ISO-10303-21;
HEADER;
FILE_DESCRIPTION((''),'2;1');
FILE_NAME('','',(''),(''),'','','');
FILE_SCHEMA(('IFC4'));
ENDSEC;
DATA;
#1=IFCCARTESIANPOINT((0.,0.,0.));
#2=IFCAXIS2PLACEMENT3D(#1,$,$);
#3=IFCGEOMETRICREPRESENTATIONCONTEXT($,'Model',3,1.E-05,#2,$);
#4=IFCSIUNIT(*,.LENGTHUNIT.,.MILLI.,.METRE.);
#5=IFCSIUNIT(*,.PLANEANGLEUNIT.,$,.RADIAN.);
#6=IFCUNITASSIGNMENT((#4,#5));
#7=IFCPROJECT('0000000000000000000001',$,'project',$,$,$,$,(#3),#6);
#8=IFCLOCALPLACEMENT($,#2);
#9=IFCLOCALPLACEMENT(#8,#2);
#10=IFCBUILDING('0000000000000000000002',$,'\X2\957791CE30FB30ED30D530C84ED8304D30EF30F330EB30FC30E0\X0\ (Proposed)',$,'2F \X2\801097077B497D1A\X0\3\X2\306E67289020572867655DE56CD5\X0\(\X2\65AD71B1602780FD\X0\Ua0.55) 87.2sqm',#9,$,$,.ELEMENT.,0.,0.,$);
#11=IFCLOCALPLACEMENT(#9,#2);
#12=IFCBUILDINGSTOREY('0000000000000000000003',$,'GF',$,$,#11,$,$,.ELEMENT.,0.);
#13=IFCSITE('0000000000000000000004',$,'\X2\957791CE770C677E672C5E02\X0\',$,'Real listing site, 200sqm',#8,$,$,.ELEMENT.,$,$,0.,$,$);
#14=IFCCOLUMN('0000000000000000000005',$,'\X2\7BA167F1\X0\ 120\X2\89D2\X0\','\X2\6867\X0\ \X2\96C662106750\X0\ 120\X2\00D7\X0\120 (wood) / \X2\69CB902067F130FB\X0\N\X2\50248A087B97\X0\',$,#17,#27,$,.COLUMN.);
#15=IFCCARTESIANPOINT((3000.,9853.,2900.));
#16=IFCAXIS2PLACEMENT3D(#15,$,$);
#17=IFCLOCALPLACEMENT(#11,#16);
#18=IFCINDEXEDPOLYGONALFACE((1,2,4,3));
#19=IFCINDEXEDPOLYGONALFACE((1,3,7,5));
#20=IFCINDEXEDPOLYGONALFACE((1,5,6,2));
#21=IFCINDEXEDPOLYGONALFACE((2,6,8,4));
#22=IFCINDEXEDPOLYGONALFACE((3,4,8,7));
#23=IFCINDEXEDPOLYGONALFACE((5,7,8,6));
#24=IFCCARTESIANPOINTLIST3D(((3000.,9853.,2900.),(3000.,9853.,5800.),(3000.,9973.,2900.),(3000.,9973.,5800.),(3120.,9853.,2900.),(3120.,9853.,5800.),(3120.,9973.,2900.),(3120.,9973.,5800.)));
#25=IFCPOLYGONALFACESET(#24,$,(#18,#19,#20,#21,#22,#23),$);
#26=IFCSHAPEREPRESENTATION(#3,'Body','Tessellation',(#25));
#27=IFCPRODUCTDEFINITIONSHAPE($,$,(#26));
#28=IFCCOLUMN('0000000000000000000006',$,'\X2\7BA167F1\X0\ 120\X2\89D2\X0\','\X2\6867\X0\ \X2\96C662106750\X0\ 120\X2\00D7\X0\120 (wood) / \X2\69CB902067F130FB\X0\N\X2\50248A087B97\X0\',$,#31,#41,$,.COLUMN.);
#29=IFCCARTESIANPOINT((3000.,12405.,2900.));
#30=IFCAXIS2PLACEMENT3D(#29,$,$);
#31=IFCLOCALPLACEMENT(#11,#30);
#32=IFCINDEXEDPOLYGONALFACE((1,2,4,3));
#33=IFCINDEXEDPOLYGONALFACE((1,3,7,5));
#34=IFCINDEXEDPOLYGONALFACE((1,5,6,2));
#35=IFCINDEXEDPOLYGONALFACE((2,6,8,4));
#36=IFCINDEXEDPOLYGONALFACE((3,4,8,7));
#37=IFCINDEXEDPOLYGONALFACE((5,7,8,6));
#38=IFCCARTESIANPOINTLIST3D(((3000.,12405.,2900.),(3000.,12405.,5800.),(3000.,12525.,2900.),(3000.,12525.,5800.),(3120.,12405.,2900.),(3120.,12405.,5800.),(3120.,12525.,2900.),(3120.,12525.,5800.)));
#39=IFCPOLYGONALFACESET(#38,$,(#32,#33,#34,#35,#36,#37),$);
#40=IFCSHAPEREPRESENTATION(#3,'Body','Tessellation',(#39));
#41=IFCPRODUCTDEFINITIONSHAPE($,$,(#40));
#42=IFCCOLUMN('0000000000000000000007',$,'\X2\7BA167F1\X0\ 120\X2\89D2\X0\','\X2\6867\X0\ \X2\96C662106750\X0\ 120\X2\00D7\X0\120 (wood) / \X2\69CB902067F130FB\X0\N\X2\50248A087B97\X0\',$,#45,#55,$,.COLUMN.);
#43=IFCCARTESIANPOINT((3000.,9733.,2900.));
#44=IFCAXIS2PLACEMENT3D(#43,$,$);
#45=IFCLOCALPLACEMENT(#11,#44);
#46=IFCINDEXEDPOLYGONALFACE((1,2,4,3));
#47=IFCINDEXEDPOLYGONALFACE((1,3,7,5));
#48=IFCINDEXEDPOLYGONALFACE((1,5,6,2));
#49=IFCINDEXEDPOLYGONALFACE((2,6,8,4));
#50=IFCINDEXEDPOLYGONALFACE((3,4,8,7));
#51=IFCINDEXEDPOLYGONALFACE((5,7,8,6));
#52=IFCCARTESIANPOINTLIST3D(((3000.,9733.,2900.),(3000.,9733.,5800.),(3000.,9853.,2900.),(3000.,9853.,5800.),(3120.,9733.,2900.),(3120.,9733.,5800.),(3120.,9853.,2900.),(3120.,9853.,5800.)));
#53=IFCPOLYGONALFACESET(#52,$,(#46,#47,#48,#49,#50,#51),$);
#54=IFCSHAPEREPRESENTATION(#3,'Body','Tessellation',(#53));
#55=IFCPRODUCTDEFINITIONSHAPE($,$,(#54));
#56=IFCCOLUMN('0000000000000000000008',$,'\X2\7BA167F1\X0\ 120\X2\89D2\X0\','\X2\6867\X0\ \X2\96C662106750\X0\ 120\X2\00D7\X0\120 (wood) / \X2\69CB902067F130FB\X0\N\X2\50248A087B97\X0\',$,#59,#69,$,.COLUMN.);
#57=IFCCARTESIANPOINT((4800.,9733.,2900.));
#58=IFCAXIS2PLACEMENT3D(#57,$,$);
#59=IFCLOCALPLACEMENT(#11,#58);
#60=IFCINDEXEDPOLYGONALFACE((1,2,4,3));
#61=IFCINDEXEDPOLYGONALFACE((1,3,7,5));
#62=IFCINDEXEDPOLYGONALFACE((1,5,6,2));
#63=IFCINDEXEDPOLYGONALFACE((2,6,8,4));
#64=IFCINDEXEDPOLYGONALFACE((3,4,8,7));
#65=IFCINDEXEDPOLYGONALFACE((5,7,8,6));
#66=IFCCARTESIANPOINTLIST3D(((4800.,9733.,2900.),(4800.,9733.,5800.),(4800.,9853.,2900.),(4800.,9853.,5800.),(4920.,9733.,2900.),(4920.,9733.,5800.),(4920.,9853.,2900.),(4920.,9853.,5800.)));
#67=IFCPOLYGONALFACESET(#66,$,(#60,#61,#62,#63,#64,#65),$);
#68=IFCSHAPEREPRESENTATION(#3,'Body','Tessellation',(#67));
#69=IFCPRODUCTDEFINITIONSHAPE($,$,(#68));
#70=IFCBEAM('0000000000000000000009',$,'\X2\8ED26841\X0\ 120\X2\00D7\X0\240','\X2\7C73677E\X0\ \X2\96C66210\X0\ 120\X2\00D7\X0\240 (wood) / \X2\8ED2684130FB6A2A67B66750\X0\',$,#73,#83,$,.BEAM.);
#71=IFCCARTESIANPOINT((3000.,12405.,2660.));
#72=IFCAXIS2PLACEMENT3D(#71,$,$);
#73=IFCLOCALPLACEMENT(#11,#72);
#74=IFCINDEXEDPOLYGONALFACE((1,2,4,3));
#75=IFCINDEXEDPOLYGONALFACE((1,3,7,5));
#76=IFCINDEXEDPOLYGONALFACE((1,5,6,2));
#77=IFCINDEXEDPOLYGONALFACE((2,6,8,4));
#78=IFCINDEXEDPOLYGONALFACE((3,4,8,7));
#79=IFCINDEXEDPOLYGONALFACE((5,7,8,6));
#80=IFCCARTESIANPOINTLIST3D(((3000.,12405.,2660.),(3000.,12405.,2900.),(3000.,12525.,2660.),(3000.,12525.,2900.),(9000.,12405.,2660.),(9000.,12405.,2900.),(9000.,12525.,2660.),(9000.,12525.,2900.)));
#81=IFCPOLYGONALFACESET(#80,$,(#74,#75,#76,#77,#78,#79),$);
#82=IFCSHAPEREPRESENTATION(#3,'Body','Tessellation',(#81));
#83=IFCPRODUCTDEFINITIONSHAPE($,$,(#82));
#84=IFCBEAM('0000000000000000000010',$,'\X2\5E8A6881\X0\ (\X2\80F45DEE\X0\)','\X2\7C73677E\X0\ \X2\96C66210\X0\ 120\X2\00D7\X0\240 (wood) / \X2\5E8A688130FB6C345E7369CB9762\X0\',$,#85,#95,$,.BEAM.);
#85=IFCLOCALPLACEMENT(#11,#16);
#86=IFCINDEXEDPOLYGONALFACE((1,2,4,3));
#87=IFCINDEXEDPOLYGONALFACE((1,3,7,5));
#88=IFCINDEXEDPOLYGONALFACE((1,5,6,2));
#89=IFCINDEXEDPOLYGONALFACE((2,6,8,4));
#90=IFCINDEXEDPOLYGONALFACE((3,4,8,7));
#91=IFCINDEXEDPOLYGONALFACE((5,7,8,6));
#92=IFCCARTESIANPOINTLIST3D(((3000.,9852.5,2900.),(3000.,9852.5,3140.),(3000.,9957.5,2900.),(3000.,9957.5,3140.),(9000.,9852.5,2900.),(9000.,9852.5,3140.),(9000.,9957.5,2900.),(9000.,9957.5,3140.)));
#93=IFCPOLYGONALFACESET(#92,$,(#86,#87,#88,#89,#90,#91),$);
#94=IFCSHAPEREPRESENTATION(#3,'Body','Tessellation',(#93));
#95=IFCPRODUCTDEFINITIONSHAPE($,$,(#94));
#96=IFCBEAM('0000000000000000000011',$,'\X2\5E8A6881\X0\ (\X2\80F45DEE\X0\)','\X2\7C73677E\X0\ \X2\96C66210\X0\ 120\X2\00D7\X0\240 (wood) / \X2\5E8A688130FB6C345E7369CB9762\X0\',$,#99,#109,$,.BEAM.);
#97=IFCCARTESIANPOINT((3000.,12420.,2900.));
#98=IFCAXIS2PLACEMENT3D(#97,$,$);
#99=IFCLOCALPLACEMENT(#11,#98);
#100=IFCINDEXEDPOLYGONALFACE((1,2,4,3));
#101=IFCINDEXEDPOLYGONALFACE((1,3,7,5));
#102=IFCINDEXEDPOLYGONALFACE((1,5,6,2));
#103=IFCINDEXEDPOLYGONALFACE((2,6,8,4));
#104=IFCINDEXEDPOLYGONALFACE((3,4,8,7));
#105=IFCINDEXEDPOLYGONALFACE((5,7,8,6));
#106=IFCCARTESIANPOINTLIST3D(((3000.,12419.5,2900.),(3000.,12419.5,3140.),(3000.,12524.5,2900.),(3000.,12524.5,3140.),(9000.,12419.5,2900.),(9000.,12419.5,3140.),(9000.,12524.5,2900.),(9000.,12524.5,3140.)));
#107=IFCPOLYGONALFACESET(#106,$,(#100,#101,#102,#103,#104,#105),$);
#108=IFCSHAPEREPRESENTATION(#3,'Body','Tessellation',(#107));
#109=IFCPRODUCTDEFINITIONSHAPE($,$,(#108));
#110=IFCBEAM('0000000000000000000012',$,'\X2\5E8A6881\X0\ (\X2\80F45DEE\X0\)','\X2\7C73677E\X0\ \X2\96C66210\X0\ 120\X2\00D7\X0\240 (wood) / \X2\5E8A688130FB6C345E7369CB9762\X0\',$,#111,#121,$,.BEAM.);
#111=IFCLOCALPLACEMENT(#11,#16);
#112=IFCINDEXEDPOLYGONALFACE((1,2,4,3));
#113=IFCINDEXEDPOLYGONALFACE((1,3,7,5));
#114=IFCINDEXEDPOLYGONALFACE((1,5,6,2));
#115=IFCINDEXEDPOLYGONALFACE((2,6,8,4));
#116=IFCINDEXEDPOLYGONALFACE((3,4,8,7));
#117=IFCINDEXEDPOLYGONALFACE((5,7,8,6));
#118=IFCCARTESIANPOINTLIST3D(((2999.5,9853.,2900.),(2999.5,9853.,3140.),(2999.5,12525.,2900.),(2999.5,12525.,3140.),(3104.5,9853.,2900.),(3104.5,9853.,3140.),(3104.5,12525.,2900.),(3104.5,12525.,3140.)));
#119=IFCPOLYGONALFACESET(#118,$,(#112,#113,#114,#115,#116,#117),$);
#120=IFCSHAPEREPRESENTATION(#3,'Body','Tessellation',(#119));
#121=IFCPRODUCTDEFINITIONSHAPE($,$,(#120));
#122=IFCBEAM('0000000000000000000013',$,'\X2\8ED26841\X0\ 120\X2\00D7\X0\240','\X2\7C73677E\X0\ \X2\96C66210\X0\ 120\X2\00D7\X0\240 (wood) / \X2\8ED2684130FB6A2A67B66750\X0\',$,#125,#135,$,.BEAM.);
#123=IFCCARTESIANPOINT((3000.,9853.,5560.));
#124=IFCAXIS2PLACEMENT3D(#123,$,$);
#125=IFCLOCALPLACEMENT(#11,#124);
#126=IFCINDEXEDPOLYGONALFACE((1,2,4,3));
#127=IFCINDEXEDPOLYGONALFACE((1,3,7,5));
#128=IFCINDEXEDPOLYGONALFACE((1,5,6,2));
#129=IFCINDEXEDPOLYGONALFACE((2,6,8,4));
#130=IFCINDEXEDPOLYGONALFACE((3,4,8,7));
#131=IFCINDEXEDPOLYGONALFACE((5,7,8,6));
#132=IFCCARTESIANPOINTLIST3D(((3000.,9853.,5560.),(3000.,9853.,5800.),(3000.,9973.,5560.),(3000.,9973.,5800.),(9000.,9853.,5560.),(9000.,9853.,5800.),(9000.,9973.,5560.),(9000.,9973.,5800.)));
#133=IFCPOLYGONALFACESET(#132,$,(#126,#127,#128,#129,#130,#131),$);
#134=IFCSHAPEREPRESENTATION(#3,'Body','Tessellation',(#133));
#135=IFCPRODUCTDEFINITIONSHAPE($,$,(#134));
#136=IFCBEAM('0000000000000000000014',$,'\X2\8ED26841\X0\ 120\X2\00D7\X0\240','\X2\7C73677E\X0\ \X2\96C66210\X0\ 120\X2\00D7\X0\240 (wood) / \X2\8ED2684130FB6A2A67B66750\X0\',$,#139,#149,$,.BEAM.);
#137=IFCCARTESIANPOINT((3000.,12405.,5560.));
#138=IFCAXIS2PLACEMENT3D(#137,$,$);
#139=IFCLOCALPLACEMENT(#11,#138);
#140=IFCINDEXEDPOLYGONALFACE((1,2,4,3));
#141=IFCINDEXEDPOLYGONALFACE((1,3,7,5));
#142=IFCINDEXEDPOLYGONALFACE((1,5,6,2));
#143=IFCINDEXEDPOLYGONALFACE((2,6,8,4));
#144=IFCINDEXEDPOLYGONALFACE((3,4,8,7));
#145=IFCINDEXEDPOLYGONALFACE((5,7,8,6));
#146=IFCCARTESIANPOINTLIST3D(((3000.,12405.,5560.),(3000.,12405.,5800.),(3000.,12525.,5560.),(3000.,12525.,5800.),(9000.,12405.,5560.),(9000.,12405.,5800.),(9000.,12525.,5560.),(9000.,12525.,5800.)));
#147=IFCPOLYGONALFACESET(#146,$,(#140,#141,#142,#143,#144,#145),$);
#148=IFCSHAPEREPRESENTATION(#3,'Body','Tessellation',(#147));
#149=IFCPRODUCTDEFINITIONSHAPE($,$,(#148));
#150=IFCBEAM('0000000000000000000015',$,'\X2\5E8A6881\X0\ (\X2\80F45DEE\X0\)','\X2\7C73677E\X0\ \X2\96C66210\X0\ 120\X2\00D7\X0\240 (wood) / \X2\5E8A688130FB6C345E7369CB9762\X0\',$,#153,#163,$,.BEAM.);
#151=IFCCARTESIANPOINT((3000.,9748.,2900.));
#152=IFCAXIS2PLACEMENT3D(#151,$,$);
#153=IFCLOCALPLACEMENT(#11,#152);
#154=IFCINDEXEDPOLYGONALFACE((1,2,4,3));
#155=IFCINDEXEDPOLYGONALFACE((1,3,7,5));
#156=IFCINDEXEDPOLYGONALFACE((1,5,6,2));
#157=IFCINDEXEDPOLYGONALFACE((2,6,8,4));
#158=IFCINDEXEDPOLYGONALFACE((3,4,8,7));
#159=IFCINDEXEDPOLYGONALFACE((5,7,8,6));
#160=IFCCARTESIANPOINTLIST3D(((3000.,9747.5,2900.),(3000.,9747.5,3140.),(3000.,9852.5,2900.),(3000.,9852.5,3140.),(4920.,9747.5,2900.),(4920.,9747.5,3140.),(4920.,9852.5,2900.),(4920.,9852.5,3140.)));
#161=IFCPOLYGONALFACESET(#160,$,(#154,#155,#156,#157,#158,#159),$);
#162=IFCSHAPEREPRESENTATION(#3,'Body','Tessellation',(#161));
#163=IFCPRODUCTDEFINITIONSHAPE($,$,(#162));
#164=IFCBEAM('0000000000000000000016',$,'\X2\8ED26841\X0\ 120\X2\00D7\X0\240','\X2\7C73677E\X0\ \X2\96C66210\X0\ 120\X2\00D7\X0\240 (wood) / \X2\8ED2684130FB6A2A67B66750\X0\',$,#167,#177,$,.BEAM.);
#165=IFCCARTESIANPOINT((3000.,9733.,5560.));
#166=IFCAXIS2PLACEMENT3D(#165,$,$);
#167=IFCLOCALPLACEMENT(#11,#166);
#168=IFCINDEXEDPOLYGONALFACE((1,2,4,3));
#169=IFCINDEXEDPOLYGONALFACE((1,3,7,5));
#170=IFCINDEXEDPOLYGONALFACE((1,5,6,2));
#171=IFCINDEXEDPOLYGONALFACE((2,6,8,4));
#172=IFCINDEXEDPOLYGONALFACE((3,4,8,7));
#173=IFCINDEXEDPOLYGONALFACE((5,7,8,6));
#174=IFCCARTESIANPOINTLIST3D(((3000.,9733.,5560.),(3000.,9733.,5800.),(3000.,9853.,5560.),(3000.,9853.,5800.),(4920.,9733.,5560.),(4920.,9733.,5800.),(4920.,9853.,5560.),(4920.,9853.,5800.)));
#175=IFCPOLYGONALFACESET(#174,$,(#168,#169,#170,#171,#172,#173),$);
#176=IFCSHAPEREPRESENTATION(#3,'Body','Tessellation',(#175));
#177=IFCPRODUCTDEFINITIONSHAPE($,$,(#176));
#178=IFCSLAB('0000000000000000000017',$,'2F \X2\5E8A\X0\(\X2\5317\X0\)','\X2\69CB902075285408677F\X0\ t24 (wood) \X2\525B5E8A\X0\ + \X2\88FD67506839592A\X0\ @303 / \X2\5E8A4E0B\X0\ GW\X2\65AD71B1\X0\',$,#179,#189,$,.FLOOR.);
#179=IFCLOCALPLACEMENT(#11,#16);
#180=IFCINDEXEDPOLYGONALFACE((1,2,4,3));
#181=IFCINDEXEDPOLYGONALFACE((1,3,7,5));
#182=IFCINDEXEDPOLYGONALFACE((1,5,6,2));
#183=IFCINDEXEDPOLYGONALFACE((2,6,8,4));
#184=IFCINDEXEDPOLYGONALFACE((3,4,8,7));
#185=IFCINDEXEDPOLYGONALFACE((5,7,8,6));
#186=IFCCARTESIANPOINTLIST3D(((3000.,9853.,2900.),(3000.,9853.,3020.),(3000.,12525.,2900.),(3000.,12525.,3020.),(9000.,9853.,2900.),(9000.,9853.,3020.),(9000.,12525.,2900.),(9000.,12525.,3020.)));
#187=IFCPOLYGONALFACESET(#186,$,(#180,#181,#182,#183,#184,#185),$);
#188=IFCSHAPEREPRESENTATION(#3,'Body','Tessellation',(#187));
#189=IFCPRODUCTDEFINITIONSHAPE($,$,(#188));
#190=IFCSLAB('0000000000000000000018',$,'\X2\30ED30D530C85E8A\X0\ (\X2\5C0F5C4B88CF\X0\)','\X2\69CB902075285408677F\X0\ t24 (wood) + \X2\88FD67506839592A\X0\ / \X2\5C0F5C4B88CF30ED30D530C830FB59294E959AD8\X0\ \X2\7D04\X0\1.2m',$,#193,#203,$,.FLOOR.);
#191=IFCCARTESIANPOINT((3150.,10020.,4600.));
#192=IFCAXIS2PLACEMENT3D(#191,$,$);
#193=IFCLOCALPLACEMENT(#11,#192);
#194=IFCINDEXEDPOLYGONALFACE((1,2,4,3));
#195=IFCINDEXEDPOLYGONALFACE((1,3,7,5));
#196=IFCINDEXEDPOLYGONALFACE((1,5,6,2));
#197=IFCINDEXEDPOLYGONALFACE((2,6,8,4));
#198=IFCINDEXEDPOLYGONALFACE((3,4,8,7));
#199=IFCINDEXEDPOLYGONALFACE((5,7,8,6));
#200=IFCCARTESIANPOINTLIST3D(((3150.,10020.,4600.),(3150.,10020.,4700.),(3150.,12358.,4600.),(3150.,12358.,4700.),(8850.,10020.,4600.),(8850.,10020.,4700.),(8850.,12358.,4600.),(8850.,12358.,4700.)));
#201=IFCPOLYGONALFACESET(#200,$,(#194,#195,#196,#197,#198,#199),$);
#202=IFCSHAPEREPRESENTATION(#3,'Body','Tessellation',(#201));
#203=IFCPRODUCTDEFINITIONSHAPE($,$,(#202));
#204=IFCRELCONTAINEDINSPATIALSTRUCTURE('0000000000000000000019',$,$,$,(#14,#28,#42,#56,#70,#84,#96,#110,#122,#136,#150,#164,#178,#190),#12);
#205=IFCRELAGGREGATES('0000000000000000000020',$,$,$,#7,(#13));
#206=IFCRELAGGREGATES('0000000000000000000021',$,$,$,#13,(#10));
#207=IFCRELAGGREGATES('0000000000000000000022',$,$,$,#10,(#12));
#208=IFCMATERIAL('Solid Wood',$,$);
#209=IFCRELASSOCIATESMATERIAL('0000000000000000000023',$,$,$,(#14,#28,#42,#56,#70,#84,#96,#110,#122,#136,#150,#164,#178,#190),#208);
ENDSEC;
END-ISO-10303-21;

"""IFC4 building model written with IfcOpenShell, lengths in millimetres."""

from ifc_helpers import new_model, si_unit, frame, frame_2d, origin, place, context, project, spatial, rectangle, extrude, material, element, save


model = new_model("IFC4")

# Units and contexts
model_context = context("Model", 3, precision=1e-05, world=origin())
ifc_project = project(units=[si_unit("LENGTHUNIT", "METRE", prefix="MILLI"), si_unit("PLANEANGLEUNIT", "RADIAN")], contexts=[model_context])

# Site, building, storey
site_placement = place(None, origin())
site = spatial("IfcSite", under=ifc_project, at=site_placement, Name="長野県松本市", ObjectType="Real listing site, 200sqm", CompositionType="ELEMENT", RefElevation=0.0)
building_placement = place(site_placement, origin())
building = spatial("IfcBuilding", under=site, at=building_placement, Name="長野・ロフト付きワンルーム (Proposed)", ObjectType="2F 耐震等級3の木造在来工法(断熱性能Ua0.55) 87.2sqm", CompositionType="ELEMENT", ElevationOfRefHeight=0.0, ElevationOfTerrain=0.0)
storey_placement = place(building_placement, origin())
storey = spatial("IfcBuildingStorey", under=building, at=storey_placement, Name="GF", CompositionType="ELEMENT", Elevation=0.0)

# Columns
ifc_material_1 = material(Name="Solid Wood")
column_1_placement = place(storey_placement, frame((3000.0, 9853.0, 2900.0)))
element("IfcColumn", 1, at=column_1_placement, inside=storey, material=ifc_material_1, Name="管柱 120角", Description="桧 集成材 120×120 (wood) / 構造柱・N値計算", PredefinedType="COLUMN", context=model_context, shape_type="SweptSolid", body=[
    extrude(rectangle(XDim=120.0, YDim=120.0, at=frame_2d((60.0, 60.0))), frame((3000.0, 9853.0, 2900.0)), (0.0, 0.0, 1.0), 2900.0),
])
column_2_placement = place(storey_placement, frame((3000.0, 12405.0, 2900.0)))
element("IfcColumn", 2, at=column_2_placement, inside=storey, material=ifc_material_1, Name="管柱 120角", Description="桧 集成材 120×120 (wood) / 構造柱・N値計算", PredefinedType="COLUMN", context=model_context, shape_type="SweptSolid", body=[
    extrude(rectangle(XDim=120.0, YDim=120.0, at=frame_2d((60.0, 60.0))), frame((3000.0, 12405.0, 2900.0)), (0.0, 0.0, 1.0), 2900.0),
])
column_3_placement = place(storey_placement, frame((3000.0, 9733.0, 2900.0)))
element("IfcColumn", 3, at=column_3_placement, inside=storey, material=ifc_material_1, Name="管柱 120角", Description="桧 集成材 120×120 (wood) / 構造柱・N値計算", PredefinedType="COLUMN", context=model_context, shape_type="SweptSolid", body=[
    extrude(rectangle(XDim=120.0, YDim=120.0, at=frame_2d((60.0, 60.0))), frame((3000.0, 9733.0, 2900.0)), (0.0, 0.0, 1.0), 2900.0),
])
column_4_placement = place(storey_placement, frame((4800.0, 9733.0, 2900.0)))
element("IfcColumn", 4, at=column_4_placement, inside=storey, material=ifc_material_1, Name="管柱 120角", Description="桧 集成材 120×120 (wood) / 構造柱・N値計算", PredefinedType="COLUMN", context=model_context, shape_type="SweptSolid", body=[
    extrude(rectangle(XDim=120.0, YDim=120.0, at=frame_2d((60.0, 60.0))), frame((4800.0, 9733.0, 2900.0)), (0.0, 0.0, 1.0), 2900.0),
])

# Beams
beam_1_placement = place(storey_placement, frame((3000.0, 12405.0, 2660.0)))
element("IfcBeam", 5, at=beam_1_placement, inside=storey, material=ifc_material_1, Name="軒桁 120×240", Description="米松 集成 120×240 (wood) / 軒桁・横架材", PredefinedType="BEAM", context=model_context, shape_type="SweptSolid", body=[
    extrude(rectangle(XDim=6000.0, YDim=120.0, at=frame_2d((3000.0, 60.0))), frame((3000.0, 12405.0, 2660.0)), (0.0, 0.0, 1.0), 240.0),
])
beam_2_placement = place(storey_placement, frame((3000.0, 9853.0, 2900.0)))
element("IfcBeam", 6, at=beam_2_placement, inside=storey, material=ifc_material_1, Name="床梁 (胴差)", Description="米松 集成 120×240 (wood) / 床梁・水平構面", PredefinedType="BEAM", context=model_context, shape_type="SweptSolid", body=[
    extrude(rectangle(XDim=6000.0, YDim=105.0, at=frame_2d((3000.0, 52.0))), frame((3000.0, 9853.0, 2900.0)), (0.0, 0.0, 1.0), 240.0),
])
beam_3_placement = place(storey_placement, frame((3000.0, 12420.0, 2900.0)))
element("IfcBeam", 7, at=beam_3_placement, inside=storey, material=ifc_material_1, Name="床梁 (胴差)", Description="米松 集成 120×240 (wood) / 床梁・水平構面", PredefinedType="BEAM", context=model_context, shape_type="SweptSolid", body=[
    extrude(rectangle(XDim=6000.0, YDim=105.0, at=frame_2d((3000.0, 52.0))), frame((3000.0, 12420.0, 2900.0)), (0.0, 0.0, 1.0), 240.0),
])
beam_4_placement = place(storey_placement, frame((3000.0, 9853.0, 2900.0)))
element("IfcBeam", 8, at=beam_4_placement, inside=storey, material=ifc_material_1, Name="床梁 (胴差)", Description="米松 集成 120×240 (wood) / 床梁・水平構面", PredefinedType="BEAM", context=model_context, shape_type="SweptSolid", body=[
    extrude(rectangle(XDim=105.0, YDim=2672.0, at=frame_2d((52.0, 1336.0))), frame((3000.0, 9853.0, 2900.0)), (0.0, 0.0, 1.0), 240.0),
])
beam_5_placement = place(storey_placement, frame((3000.0, 9853.0, 5560.0)))
element("IfcBeam", 9, at=beam_5_placement, inside=storey, material=ifc_material_1, Name="軒桁 120×240", Description="米松 集成 120×240 (wood) / 軒桁・横架材", PredefinedType="BEAM", context=model_context, shape_type="SweptSolid", body=[
    extrude(rectangle(XDim=6000.0, YDim=120.0, at=frame_2d((3000.0, 60.0))), frame((3000.0, 9853.0, 5560.0)), (0.0, 0.0, 1.0), 240.0),
])
beam_6_placement = place(storey_placement, frame((3000.0, 12405.0, 5560.0)))
element("IfcBeam", 10, at=beam_6_placement, inside=storey, material=ifc_material_1, Name="軒桁 120×240", Description="米松 集成 120×240 (wood) / 軒桁・横架材", PredefinedType="BEAM", context=model_context, shape_type="SweptSolid", body=[
    extrude(rectangle(XDim=6000.0, YDim=120.0, at=frame_2d((3000.0, 60.0))), frame((3000.0, 12405.0, 5560.0)), (0.0, 0.0, 1.0), 240.0),
])
beam_7_placement = place(storey_placement, frame((3000.0, 9748.0, 2900.0)))
element("IfcBeam", 11, at=beam_7_placement, inside=storey, material=ifc_material_1, Name="床梁 (胴差)", Description="米松 集成 120×240 (wood) / 床梁・水平構面", PredefinedType="BEAM", context=model_context, shape_type="SweptSolid", body=[
    extrude(rectangle(XDim=1920.0, YDim=105.0, at=frame_2d((960.0, 52.0))), frame((3000.0, 9748.0, 2900.0)), (0.0, 0.0, 1.0), 240.0),
])
beam_8_placement = place(storey_placement, frame((3000.0, 9733.0, 5560.0)))
element("IfcBeam", 12, at=beam_8_placement, inside=storey, material=ifc_material_1, Name="軒桁 120×240", Description="米松 集成 120×240 (wood) / 軒桁・横架材", PredefinedType="BEAM", context=model_context, shape_type="SweptSolid", body=[
    extrude(rectangle(XDim=1920.0, YDim=120.0, at=frame_2d((960.0, 60.0))), frame((3000.0, 9733.0, 5560.0)), (0.0, 0.0, 1.0), 240.0),
])

# Slabs
slab_1_placement = place(storey_placement, frame((3000.0, 9853.0, 2900.0)))
element("IfcSlab", 13, at=slab_1_placement, inside=storey, material=ifc_material_1, Name="2F 床(北)", Description="構造用合板 t24 (wood) 剛床 + 製材根太 @303 / 床下 GW断熱", PredefinedType="FLOOR", context=model_context, shape_type="SweptSolid", body=[
    extrude(rectangle(XDim=6000.0, YDim=2672.0, at=frame_2d((3000.0, 1336.0))), frame((3000.0, 9853.0, 2900.0)), (0.0, 0.0, 1.0), 120.0),
])
slab_2_placement = place(storey_placement, frame((3150.0, 10020.0, 4600.0)))
element("IfcSlab", 14, at=slab_2_placement, inside=storey, material=ifc_material_1, Name="ロフト床 (小屋裏)", Description="構造用合板 t24 (wood) + 製材根太 / 小屋裏ロフト・天井高 約1.2m", PredefinedType="FLOOR", context=model_context, shape_type="SweptSolid", body=[
    extrude(rectangle(XDim=5700.0, YDim=2338.0, at=frame_2d((2850.0, 1169.0))), frame((3150.0, 10020.0, 4600.0)), (0.0, 0.0, 1.0), 100.0),
])

save(model, "model.ifc")
